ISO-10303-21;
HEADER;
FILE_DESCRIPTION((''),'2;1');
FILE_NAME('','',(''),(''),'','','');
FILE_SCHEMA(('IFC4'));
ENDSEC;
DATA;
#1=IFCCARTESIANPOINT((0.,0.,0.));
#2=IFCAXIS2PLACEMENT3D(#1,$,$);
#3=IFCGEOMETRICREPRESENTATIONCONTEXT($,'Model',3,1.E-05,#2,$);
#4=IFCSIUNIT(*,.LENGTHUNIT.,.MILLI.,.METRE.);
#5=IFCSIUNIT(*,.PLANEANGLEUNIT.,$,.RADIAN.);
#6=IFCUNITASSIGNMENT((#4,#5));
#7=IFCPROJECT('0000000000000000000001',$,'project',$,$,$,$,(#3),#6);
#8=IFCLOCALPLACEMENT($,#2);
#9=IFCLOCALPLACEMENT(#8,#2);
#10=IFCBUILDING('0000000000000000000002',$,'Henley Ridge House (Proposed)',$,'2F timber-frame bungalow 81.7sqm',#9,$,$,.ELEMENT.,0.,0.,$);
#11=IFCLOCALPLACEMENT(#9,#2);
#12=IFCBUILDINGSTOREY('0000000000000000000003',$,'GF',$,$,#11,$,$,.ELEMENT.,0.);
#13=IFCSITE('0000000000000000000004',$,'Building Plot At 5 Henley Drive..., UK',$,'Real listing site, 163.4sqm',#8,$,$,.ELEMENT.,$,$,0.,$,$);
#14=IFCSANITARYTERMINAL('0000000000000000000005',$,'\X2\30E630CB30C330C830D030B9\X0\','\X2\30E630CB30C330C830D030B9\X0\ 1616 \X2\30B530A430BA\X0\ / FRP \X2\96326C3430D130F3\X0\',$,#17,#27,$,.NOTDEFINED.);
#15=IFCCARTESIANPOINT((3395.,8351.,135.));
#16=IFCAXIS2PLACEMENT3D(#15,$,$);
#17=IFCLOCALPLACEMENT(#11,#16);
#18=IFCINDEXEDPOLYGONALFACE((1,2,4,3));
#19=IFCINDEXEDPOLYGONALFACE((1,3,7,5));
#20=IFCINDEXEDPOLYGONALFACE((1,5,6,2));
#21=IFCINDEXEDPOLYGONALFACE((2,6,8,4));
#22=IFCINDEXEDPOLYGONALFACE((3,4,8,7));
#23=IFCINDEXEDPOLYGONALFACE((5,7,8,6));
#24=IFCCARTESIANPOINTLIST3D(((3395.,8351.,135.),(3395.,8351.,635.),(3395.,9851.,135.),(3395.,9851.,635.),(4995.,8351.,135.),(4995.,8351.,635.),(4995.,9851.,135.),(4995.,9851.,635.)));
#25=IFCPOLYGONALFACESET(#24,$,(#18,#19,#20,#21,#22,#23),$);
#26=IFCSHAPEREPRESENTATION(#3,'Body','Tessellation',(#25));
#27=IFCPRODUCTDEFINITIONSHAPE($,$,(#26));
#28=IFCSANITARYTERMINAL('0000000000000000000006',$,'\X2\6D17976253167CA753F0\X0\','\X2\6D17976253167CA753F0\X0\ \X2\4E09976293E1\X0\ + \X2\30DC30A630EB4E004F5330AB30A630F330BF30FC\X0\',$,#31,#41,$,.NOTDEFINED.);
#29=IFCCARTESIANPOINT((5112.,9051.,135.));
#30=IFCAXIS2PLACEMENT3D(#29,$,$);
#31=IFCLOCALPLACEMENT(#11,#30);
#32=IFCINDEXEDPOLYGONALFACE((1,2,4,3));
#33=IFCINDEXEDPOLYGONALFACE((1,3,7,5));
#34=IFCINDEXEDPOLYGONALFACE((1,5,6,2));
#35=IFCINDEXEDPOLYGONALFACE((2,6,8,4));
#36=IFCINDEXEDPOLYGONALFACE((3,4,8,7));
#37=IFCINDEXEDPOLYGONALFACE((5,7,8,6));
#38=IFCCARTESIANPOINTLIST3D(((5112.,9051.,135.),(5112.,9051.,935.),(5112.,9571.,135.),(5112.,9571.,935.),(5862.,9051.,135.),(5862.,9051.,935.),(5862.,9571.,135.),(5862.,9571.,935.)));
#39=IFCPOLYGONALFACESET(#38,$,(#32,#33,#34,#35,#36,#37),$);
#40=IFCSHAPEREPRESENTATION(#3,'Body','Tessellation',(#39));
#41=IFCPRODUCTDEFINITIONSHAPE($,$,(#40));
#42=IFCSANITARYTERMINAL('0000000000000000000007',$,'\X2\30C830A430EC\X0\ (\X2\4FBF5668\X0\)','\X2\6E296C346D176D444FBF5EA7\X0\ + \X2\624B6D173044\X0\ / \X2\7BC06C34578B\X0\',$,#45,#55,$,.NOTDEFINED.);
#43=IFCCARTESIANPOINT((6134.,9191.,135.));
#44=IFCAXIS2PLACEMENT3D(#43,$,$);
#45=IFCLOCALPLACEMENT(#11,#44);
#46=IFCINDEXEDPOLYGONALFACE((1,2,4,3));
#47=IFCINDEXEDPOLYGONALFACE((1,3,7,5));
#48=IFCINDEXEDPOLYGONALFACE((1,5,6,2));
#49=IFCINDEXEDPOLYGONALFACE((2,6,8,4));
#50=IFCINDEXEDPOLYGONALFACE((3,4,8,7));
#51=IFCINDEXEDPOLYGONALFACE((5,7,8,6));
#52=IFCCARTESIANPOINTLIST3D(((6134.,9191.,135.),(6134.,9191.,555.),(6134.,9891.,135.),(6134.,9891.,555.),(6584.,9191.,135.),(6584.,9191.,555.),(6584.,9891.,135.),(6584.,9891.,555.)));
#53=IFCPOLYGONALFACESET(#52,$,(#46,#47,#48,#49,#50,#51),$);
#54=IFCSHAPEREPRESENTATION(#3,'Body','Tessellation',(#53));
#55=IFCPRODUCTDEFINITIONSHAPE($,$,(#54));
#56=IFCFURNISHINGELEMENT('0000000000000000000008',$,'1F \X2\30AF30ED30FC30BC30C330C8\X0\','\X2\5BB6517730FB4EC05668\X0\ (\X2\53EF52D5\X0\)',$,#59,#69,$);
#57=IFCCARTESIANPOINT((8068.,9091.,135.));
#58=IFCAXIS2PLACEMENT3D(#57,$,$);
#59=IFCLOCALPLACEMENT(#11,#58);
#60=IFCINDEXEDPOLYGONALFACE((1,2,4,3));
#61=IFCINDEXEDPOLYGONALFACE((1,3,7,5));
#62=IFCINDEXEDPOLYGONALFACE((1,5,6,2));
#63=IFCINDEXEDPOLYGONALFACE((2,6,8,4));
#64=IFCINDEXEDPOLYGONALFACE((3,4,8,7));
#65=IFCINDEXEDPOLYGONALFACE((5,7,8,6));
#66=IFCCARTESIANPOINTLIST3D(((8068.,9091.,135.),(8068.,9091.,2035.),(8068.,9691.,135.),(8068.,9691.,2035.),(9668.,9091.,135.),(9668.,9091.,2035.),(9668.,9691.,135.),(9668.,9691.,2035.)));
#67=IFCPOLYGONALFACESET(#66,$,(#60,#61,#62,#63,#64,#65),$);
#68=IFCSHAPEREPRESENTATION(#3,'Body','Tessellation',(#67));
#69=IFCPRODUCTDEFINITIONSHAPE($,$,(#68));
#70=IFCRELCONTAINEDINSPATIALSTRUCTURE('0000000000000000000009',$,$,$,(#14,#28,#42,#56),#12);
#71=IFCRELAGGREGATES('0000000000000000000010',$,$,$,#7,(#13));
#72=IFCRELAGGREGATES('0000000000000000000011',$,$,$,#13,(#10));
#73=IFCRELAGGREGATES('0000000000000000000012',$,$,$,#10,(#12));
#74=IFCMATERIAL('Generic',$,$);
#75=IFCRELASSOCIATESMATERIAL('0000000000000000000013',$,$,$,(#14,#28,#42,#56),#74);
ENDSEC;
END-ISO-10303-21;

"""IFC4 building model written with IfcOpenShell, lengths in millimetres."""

from ifc_helpers import new_model, si_unit, frame, frame_2d, origin, place, context, project, spatial, rectangle, extrude, material, element, save


model = new_model("IFC4")

# Units and contexts
model_context = context("Model", 3, precision=1e-05, world=origin())
ifc_project = project(units=[si_unit("LENGTHUNIT", "METRE", prefix="MILLI"), si_unit("PLANEANGLEUNIT", "RADIAN")], contexts=[model_context])

# Site, building, storey
site_placement = place(None, origin())
site = spatial("IfcSite", under=ifc_project, at=site_placement, Name="Building Plot At 5 Henley Drive..., UK", ObjectType="Real listing site, 163.4sqm", CompositionType="ELEMENT", RefElevation=0.0)
building_placement = place(site_placement, origin())
building = spatial("IfcBuilding", under=site, at=building_placement, Name="Henley Ridge House (Proposed)", ObjectType="2F timber-frame bungalow 81.7sqm", CompositionType="ELEMENT", ElevationOfRefHeight=0.0, ElevationOfTerrain=0.0)
storey_placement = place(building_placement, origin())
storey = spatial("IfcBuildingStorey", under=building, at=storey_placement, Name="GF", CompositionType="ELEMENT", Elevation=0.0)

# Shared definitions
ifc_material_1 = material(Name="Generic")

# Sanitary terminals
sanitary_terminal_1_placement = place(storey_placement, frame((3395.0, 8351.0, 135.0)))
element("IfcSanitaryTerminal", 1, at=sanitary_terminal_1_placement, inside=storey, material=ifc_material_1, Name="ユニットバス", Description="ユニットバス 1616 サイズ / FRP 防水パン", PredefinedType="NOTDEFINED", context=model_context, shape_type="SweptSolid", body=[
    extrude(rectangle(XDim=1600.0, YDim=1500.0, at=frame_2d((800.0, 750.0))), frame((3395.0, 8351.0, 135.0)), (0.0, 0.0, 1.0), 500.0),
])
sanitary_terminal_2_placement = place(storey_placement, frame((5112.0, 9051.0, 135.0)))
element("IfcSanitaryTerminal", 2, at=sanitary_terminal_2_placement, inside=storey, material=ifc_material_1, Name="洗面化粧台", Description="洗面化粧台 三面鏡 + ボウル一体カウンター", PredefinedType="NOTDEFINED", context=model_context, shape_type="SweptSolid", body=[
    extrude(rectangle(XDim=750.0, YDim=520.0, at=frame_2d((375.0, 260.0))), frame((5112.0, 9051.0, 135.0)), (0.0, 0.0, 1.0), 800.0),
])
sanitary_terminal_3_placement = place(storey_placement, frame((6134.0, 9191.0, 135.0)))
element("IfcSanitaryTerminal", 3, at=sanitary_terminal_3_placement, inside=storey, material=ifc_material_1, Name="トイレ (便器)", Description="温水洗浄便座 + 手洗い / 節水型", PredefinedType="NOTDEFINED", context=model_context, shape_type="SweptSolid", body=[
    extrude(rectangle(XDim=450.0, YDim=700.0, at=frame_2d((225.0, 350.0))), frame((6134.0, 9191.0, 135.0)), (0.0, 0.0, 1.0), 420.0),
])

# Furnishing element
furnishing_placement = place(storey_placement, frame((8068.0, 9091.0, 135.0)))
element("IfcFurnishingElement", 4, at=furnishing_placement, inside=storey, material=ifc_material_1, Name="1F クローゼット", Description="家具・什器 (可動)", context=model_context, shape_type="SweptSolid", body=[
    extrude(rectangle(XDim=1600.0, YDim=600.0, at=frame_2d((800.0, 300.0))), frame((8068.0, 9091.0, 135.0)), (0.0, 0.0, 1.0), 1900.0),
])

save(model, "model.ifc")
